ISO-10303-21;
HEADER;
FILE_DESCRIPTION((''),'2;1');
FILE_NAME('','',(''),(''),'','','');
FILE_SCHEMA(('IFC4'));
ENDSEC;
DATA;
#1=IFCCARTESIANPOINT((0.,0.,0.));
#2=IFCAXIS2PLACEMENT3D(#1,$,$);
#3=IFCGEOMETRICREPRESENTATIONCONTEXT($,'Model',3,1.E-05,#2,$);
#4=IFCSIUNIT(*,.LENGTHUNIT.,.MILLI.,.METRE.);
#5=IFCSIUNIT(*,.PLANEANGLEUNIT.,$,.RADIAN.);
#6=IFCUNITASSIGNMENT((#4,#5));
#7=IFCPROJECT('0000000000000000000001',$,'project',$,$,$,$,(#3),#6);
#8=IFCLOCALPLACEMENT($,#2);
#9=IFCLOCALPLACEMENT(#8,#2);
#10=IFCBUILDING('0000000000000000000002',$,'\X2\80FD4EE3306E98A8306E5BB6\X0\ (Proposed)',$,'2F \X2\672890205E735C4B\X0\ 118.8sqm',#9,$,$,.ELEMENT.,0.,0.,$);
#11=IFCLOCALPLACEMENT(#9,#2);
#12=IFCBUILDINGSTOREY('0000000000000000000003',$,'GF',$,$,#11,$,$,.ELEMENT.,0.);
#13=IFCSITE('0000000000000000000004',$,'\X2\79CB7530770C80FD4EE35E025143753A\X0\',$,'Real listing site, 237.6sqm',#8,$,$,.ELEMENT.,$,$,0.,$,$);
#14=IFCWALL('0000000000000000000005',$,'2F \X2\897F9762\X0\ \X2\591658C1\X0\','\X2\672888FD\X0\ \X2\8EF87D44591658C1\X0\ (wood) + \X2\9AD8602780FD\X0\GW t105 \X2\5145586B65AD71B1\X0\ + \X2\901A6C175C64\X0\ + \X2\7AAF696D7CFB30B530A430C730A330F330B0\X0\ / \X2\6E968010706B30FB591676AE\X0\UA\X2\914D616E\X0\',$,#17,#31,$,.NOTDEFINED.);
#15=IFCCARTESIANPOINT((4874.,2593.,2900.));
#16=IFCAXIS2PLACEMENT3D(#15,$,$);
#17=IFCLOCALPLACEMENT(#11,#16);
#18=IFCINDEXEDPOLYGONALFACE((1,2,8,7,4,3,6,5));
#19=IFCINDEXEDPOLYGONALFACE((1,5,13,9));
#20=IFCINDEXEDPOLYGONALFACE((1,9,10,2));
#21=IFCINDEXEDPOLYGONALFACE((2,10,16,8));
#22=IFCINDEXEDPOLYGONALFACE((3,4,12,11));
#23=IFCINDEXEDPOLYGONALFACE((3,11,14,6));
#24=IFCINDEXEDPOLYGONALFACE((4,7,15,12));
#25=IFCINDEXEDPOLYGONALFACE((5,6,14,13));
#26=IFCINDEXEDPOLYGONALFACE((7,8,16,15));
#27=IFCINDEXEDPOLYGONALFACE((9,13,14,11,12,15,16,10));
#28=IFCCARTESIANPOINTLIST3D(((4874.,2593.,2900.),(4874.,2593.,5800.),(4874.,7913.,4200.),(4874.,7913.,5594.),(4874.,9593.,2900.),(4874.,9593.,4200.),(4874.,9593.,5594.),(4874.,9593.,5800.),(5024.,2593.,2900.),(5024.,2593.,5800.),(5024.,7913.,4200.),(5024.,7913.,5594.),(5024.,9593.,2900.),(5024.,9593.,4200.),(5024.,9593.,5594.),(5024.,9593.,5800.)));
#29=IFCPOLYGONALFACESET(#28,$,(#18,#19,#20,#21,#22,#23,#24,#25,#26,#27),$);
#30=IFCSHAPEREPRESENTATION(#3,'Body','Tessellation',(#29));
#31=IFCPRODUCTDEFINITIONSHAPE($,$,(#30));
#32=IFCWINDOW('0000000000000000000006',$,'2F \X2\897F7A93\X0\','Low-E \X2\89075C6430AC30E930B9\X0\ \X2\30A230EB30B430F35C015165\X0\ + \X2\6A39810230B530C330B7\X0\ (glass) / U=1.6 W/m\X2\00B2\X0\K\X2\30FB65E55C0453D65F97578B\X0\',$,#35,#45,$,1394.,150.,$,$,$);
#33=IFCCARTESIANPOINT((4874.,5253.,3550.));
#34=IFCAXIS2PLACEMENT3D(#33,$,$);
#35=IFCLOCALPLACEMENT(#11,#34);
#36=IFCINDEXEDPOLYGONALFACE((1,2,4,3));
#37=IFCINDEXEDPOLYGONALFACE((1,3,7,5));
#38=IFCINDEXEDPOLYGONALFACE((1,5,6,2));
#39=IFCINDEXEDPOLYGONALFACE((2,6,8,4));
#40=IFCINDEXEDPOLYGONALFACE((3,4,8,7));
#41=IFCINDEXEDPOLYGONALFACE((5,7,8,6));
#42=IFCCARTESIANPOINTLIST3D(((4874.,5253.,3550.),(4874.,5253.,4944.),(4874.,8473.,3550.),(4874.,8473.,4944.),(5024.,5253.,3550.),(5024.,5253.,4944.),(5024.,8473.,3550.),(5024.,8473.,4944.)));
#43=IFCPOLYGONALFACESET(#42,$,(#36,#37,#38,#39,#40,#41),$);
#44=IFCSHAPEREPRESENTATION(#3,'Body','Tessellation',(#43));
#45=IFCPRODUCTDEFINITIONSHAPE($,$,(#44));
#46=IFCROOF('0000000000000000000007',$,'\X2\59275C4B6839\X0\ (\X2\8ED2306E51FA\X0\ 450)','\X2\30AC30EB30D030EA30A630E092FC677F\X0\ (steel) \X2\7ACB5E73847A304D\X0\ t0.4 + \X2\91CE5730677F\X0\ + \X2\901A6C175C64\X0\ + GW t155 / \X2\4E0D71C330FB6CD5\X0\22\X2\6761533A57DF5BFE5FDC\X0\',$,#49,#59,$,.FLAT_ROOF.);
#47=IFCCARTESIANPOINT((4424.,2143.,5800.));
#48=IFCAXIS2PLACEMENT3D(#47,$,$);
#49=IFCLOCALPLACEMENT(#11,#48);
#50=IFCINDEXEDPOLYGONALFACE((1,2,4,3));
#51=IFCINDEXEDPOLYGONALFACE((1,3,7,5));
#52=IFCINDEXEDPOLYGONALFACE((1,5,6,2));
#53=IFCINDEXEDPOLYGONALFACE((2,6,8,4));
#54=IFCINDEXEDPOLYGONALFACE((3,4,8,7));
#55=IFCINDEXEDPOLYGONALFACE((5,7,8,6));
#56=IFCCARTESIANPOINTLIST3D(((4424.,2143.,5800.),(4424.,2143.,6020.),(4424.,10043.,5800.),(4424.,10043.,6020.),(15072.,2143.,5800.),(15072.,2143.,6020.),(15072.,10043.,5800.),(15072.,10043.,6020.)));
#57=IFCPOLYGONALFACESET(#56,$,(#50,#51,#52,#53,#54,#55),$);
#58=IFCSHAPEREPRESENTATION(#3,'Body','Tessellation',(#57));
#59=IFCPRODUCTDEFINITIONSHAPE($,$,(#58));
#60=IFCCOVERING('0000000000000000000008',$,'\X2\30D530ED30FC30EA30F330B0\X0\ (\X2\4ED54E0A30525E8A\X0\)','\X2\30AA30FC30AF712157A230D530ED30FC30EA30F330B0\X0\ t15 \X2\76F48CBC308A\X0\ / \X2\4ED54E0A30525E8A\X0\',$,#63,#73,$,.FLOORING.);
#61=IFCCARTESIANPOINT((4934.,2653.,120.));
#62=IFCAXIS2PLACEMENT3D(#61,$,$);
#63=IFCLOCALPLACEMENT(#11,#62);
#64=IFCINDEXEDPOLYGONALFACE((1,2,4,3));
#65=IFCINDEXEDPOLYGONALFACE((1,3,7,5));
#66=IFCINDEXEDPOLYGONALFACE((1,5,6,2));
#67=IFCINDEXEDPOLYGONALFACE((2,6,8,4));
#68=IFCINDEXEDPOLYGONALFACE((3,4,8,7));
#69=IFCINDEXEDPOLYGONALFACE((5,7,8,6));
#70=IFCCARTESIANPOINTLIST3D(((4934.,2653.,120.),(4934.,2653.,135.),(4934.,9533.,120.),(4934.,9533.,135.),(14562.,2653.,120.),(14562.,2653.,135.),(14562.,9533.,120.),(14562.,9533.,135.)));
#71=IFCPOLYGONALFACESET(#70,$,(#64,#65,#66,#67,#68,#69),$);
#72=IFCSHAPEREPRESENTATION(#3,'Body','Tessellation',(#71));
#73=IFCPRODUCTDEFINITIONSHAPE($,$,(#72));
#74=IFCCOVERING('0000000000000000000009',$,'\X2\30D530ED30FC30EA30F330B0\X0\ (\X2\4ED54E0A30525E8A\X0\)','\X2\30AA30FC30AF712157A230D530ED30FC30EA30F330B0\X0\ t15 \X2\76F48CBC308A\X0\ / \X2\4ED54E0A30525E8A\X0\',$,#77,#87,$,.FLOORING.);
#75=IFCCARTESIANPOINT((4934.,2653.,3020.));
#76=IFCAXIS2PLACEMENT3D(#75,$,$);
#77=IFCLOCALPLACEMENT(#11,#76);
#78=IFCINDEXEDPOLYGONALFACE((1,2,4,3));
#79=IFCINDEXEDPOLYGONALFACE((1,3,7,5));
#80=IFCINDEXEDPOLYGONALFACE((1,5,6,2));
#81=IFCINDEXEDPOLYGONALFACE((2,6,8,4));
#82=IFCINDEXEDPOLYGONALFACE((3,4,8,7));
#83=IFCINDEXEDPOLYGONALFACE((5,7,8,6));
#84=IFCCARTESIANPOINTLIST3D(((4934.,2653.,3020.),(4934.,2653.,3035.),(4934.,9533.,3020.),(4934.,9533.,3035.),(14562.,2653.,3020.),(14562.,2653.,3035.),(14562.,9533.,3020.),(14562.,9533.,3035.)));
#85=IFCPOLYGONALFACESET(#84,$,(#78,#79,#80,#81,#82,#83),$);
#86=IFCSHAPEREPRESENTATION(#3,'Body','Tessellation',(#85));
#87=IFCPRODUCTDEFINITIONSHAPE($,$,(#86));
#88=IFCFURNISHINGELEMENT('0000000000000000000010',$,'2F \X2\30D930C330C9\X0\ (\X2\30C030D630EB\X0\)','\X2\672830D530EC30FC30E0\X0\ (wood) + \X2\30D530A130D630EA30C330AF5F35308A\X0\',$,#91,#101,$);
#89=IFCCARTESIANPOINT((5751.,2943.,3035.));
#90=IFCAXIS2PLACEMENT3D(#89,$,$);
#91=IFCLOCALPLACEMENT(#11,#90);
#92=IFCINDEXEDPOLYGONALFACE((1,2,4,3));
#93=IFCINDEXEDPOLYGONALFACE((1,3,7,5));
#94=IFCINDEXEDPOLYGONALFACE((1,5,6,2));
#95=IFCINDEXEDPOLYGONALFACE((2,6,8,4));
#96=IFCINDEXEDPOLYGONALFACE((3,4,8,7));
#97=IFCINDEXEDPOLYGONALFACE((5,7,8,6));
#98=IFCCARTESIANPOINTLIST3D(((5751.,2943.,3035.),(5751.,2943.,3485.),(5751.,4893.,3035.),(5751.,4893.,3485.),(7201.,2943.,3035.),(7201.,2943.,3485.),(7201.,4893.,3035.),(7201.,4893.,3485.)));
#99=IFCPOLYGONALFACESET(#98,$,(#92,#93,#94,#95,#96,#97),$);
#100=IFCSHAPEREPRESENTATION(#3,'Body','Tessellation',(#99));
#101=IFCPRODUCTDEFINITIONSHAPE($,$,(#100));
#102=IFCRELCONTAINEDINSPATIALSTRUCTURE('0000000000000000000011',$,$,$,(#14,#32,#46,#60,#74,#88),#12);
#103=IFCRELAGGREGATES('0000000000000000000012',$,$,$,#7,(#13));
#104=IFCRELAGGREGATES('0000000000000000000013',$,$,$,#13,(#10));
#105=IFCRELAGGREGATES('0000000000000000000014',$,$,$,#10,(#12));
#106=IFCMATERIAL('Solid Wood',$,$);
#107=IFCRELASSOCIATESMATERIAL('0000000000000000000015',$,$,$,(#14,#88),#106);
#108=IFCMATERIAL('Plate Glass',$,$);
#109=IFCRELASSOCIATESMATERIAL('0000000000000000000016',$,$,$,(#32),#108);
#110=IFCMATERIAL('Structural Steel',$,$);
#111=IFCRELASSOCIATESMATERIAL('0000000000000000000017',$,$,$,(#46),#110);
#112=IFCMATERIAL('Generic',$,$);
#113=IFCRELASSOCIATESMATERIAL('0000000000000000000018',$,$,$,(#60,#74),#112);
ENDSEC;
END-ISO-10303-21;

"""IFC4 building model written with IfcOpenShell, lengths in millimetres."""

from ifc_helpers import new_model, si_unit, frame, frame_2d, origin, place, context, project, spatial, rectangle, extrude, material, element, fill, save


model = new_model("IFC4")

# Units and contexts
model_context = context("Model", 3, precision=1e-05, world=origin())
ifc_project = project(units=[si_unit("LENGTHUNIT", "METRE", prefix="MILLI"), si_unit("PLANEANGLEUNIT", "RADIAN")], contexts=[model_context])

# Site, building, storey
site_placement = place(None, origin())
site = spatial("IfcSite", under=ifc_project, at=site_placement, Name="秋田県能代市元町", ObjectType="Real listing site, 237.6sqm", CompositionType="ELEMENT", RefElevation=0.0)
building_placement = place(site_placement, origin())
building = spatial("IfcBuilding", under=site, at=building_placement, Name="能代の風の家 (Proposed)", ObjectType="2F 木造平屋 118.8sqm", CompositionType="ELEMENT", ElevationOfRefHeight=0.0, ElevationOfTerrain=0.0)
storey_placement = place(building_placement, origin())
storey = spatial("IfcBuildingStorey", under=building, at=storey_placement, Name="GF", CompositionType="ELEMENT", Elevation=0.0)

# Shared definitions
ifc_material_1 = material(Name="Solid Wood")

# Shared definitions
ifc_material_2 = material(Name="Plate Glass")

# Wall, opening, window
wall_1_placement = place(storey_placement, frame((4874.0, 2593.0, 2900.0)))
wall_1 = element("IfcWall", 1, at=wall_1_placement, inside=storey, material=ifc_material_1, Name="2F 西面 外壁", Description="木製 軸組外壁 (wood) + 高性能GW t105 充填断熱 + 通気層 + 窯業系サイディング / 準耐火・外皮UA配慮", PredefinedType="NOTDEFINED", context=model_context, shape_type="SweptSolid", body=[
    extrude(rectangle(XDim=150.0, YDim=7000.0, at=frame_2d((75.0, 3500.0))), frame((4874.0, 2593.0, 2900.0)), (0.0, 0.0, 1.0), 2900.0),
])
opening_1_placement = place(storey_placement, frame((4874.0, 5253.0, 3550.0)))
opening_1 = element("IfcOpeningElement", 2, at=opening_1_placement, cuts=wall_1, PredefinedType="NOTDEFINED", context=model_context, shape_type="SweptSolid", body=[
    extrude(rectangle(XDim=150.0, YDim=3220.0, at=frame_2d((75.0, 1610.0))), frame((4874.0, 5253.0, 3550.0)), (0.0, 0.0, 1.0), 1394.0),
])
window_1_placement = place(storey_placement, frame((4874.0, 5253.0, 3550.0)))
window_1 = element("IfcWindow", 3, at=window_1_placement, inside=storey, material=ifc_material_2, Name="2F 西窓", Description="Low-E 複層ガラス アルゴン封入 + 樹脂サッシ (glass) / U=1.6 W/m²K・日射取得型", OverallHeight=1394.0, OverallWidth=150.0, context=model_context, shape_type="SweptSolid", body=[
    extrude(rectangle(XDim=150.0, YDim=3220.0, at=frame_2d((75.0, 1610.0))), frame((4874.0, 5253.0, 3550.0)), (0.0, 0.0, 1.0), 1394.0),
])
fill(opening_1, window_1)

# Roof
ifc_material_3 = material(Name="Structural Steel")
roof_placement = place(storey_placement, frame((4424.0, 2143.0, 5800.0)))
element("IfcRoof", 4, at=roof_placement, inside=storey, material=ifc_material_3, Name="大屋根 (軒の出 450)", Description="ガルバリウム鋼板 (steel) 立平葺き t0.4 + 野地板 + 通気層 + GW t155 / 不燃・法22条区域対応", PredefinedType="FLAT_ROOF", context=model_context, shape_type="SweptSolid", body=[
    extrude(rectangle(XDim=10648.0, YDim=7900.0, at=frame_2d((5324.0, 3950.0))), frame((4424.0, 2143.0, 5800.0)), (0.0, 0.0, 1.0), 220.0),
])

# Coverings
ifc_material_4 = material(Name="Generic")
covering_1_placement = place(storey_placement, frame((4934.0, 2653.0, 120.0)))
element("IfcCovering", 5, at=covering_1_placement, inside=storey, material=ifc_material_4, Name="フローリング (仕上げ床)", Description="オーク無垢フローリング t15 直貼り / 仕上げ床", PredefinedType="FLOORING", context=model_context, shape_type="SweptSolid", body=[
    extrude(rectangle(XDim=9628.0, YDim=6880.0, at=frame_2d((4814.0, 3440.0))), frame((4934.0, 2653.0, 120.0)), (0.0, 0.0, 1.0), 15.0),
])
covering_2_placement = place(storey_placement, frame((4934.0, 2653.0, 3020.0)))
element("IfcCovering", 6, at=covering_2_placement, inside=storey, material=ifc_material_4, Name="フローリング (仕上げ床)", Description="オーク無垢フローリング t15 直貼り / 仕上げ床", PredefinedType="FLOORING", context=model_context, shape_type="SweptSolid", body=[
    extrude(rectangle(XDim=9628.0, YDim=6880.0, at=frame_2d((4814.0, 3440.0))), frame((4934.0, 2653.0, 3020.0)), (0.0, 0.0, 1.0), 15.0),
])

# Furnishing element
furnishing_placement = place(storey_placement, frame((5751.0, 2943.0, 3035.0)))
element("IfcFurnishingElement", 7, at=furnishing_placement, inside=storey, material=ifc_material_1, Name="2F ベッド (ダブル)", Description="木フレーム (wood) + ファブリック張り", context=model_context, shape_type="SweptSolid", body=[
    extrude(rectangle(XDim=1450.0, YDim=1950.0, at=frame_2d((725.0, 975.0))), frame((5751.0, 2943.0, 3035.0)), (0.0, 0.0, 1.0), 450.0),
])

save(model, "model.ifc")
